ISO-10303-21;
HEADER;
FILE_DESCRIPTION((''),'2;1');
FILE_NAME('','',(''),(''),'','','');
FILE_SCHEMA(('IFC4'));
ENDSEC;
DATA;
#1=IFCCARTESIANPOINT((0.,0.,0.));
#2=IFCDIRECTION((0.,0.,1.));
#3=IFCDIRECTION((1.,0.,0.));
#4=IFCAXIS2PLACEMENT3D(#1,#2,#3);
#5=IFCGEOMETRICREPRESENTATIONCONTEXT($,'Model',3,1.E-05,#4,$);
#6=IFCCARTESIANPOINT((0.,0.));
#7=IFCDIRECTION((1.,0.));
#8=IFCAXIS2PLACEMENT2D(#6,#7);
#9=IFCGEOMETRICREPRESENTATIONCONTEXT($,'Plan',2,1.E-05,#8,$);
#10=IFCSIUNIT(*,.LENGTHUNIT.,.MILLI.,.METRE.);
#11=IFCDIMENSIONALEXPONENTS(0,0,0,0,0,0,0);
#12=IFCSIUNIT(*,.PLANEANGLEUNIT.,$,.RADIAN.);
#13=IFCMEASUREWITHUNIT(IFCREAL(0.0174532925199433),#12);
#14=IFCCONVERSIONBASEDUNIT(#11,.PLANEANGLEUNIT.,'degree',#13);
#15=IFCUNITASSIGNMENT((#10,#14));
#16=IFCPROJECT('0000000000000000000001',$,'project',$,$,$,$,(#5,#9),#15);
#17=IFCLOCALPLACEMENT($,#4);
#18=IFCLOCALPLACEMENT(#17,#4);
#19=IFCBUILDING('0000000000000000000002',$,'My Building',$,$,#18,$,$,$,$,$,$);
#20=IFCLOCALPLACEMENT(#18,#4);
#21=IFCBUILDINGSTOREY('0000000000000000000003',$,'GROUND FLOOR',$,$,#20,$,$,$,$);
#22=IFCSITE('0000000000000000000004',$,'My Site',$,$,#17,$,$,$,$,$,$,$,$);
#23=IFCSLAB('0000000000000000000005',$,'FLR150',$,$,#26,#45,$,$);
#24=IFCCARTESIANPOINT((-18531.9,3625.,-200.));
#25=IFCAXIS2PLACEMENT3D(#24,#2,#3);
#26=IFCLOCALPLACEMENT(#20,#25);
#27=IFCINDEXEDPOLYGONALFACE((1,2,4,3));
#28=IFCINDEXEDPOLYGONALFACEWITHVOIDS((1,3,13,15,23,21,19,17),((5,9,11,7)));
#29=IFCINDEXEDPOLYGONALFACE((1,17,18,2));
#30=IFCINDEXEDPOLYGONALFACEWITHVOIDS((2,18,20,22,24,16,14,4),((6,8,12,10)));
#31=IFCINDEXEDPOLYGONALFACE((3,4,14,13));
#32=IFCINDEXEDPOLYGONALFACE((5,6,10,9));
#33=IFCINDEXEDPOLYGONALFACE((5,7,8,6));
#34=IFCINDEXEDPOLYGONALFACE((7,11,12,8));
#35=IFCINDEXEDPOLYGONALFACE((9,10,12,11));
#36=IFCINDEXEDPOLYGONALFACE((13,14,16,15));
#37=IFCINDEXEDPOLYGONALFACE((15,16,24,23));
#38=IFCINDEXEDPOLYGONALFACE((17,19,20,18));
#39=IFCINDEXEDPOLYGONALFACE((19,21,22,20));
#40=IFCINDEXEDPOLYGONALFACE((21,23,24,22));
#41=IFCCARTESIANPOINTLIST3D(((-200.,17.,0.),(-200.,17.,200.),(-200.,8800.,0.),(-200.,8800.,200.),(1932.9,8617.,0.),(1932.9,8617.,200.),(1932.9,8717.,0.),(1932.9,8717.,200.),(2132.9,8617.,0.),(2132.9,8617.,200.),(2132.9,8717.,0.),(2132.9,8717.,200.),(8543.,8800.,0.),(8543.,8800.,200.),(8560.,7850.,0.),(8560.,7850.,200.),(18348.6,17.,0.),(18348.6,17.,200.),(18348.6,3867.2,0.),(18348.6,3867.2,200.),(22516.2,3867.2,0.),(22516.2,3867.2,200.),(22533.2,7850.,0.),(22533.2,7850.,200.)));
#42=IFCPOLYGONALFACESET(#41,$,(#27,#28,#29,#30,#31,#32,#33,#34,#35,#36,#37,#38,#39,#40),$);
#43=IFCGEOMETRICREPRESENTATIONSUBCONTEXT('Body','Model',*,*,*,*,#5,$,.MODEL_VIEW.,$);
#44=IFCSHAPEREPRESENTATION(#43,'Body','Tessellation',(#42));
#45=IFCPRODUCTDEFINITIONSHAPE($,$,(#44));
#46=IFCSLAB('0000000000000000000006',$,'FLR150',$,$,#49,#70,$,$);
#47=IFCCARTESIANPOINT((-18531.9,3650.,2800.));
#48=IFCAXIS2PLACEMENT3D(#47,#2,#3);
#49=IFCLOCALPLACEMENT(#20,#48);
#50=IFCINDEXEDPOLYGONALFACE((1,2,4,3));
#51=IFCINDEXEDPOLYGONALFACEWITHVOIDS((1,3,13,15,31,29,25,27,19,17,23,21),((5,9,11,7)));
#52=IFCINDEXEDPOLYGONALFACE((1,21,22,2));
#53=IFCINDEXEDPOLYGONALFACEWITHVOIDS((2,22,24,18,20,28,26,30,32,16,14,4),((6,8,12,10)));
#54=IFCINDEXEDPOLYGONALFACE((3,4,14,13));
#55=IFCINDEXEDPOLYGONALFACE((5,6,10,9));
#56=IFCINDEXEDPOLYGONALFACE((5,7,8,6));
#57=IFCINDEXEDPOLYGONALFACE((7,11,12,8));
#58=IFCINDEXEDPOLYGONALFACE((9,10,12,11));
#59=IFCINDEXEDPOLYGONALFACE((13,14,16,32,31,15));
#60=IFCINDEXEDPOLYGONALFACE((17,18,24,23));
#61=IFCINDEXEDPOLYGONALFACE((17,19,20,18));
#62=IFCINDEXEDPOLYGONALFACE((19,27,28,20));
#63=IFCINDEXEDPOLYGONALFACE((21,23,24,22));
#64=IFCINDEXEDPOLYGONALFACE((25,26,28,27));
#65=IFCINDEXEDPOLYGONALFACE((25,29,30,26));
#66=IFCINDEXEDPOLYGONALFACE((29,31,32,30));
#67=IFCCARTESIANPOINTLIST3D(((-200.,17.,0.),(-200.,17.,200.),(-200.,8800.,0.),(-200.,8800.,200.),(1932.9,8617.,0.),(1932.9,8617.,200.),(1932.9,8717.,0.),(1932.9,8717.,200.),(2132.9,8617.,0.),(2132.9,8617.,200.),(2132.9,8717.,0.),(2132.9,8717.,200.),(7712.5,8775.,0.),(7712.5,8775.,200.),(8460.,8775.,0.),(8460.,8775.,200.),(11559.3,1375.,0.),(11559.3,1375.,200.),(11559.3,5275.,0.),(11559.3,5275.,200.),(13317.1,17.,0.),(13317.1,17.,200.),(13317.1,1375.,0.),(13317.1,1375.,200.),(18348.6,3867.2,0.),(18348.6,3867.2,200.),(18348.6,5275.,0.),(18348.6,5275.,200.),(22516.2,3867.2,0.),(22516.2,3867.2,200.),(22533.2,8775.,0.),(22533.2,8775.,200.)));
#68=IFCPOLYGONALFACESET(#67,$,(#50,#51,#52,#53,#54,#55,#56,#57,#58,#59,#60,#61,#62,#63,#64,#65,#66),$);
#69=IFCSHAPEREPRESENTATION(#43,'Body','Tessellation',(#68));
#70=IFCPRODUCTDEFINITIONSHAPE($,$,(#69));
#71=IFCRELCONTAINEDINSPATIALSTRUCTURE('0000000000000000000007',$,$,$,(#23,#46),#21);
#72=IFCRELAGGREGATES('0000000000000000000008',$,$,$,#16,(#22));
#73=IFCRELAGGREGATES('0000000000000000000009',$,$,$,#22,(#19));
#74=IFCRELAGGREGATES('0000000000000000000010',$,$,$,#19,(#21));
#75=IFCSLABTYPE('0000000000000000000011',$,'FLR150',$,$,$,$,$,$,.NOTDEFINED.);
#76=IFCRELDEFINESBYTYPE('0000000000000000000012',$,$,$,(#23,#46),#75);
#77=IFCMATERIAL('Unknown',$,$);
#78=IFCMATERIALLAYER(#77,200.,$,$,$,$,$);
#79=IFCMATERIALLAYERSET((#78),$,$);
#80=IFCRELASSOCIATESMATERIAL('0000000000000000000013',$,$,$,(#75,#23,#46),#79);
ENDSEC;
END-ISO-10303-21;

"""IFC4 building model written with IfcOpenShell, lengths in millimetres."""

from ifc_helpers import new_model, entity, si_unit, converted_unit, frame, origin_with_axes, origin_2d_with_axis, place, context, subcontext, project, spatial, line, indexed_curve, outline, extrude, material, layer, layer_set, layer_usage, type_object, element, save


model = new_model("IFC4")

# Units and contexts
model_context = context("Model", 3, precision=1e-05, world=origin_with_axes())
plan_context = context("Plan", 2, precision=1e-05, world=origin_2d_with_axis())
body_context_1 = subcontext(model_context, "Body", "Model", "MODEL_VIEW")
ifc_project = project(units=[si_unit("LENGTHUNIT", "METRE", prefix="MILLI"), converted_unit("PLANEANGLEUNIT", "degree", entity("IfcReal", 0.0174532925199433), si_unit("PLANEANGLEUNIT", "RADIAN"), dimensions=[0, 0, 0, 0, 0, 0, 0])], contexts=[model_context, plan_context])

# Site, building, storey
site_placement = place(None, origin_with_axes())
site = spatial("IfcSite", under=ifc_project, at=site_placement, Name="My Site")
building_placement = place(site_placement, origin_with_axes())
building = spatial("IfcBuilding", under=site, at=building_placement, Name="My Building")
storey_placement = place(building_placement, origin_with_axes())
storey = spatial("IfcBuildingStorey", under=building, at=storey_placement, Name="GROUND FLOOR")

# Slabs
ifc_material_1 = material(Name="Unknown")
ifc_layer_1 = layer(ifc_material_1, 200.0)
ifc_layer_set_1 = layer_set([ifc_layer_1])
ifc_layer_usage_1 = layer_usage(ifc_layer_set_1, "AXIS3", "POSITIVE", 0.0)
slab_type = type_object("IfcSlabType", Name="FLR150", PredefinedType="NOTDEFINED", material=ifc_layer_set_1)
slab_1_placement = place(storey_placement, frame((-18531.9, 3625.0, -200.0), z_axis=(0.0, 0.0, 1.0), x_axis=(1.0, 0.0, 0.0)))
element("IfcSlab", 1, at=slab_1_placement, inside=storey, type_object=slab_type, material=ifc_layer_usage_1, Name="FLR150", context=body_context_1, shape_type="SweptSolid", body=[
    extrude(outline(indexed_curve([(22533.2, 7850.0), (18348.6, 3867.2), (-200.0, 17.0), (-200.0, 8800.0), (8543.0, 8800.0), (1932.9, 8617.0), (2132.9, 8617.0), (2132.9, 8717.0), (1932.9, 8717.0), (8560.0, 7850.0), (22516.2, 3867.2), (18348.6, 17.0)], segments=[line(5, 10), line(10, 1), line(1, 11), line(11, 2), line(2, 12), line(12, 3), line(3, 4), line(4, 5)], self_intersect=False), holes=[indexed_curve([(22533.2, 7850.0), (18348.6, 3867.2), (-200.0, 17.0), (-200.0, 8800.0), (8543.0, 8800.0), (1932.9, 8617.0), (2132.9, 8617.0), (2132.9, 8717.0), (1932.9, 8717.0), (8560.0, 7850.0), (22516.2, 3867.2), (18348.6, 17.0)], segments=[line(8, 7), line(7, 6), line(6, 9), line(9, 8)], self_intersect=False)]), None, (0.0, 0.0, 1.0), 200.0),
])
ifc_layer_usage_2 = layer_usage(ifc_layer_set_1, "AXIS3", "POSITIVE", 0.0)
slab_2_placement = place(storey_placement, frame((-18531.9, 3650.0, 2800.0), z_axis=(0.0, 0.0, 1.0), x_axis=(1.0, 0.0, 0.0)))
element("IfcSlab", 2, at=slab_2_placement, inside=storey, type_object=slab_type, material=ifc_layer_usage_2, Name="FLR150", context=body_context_1, shape_type="SweptSolid", body=[
    extrude(outline(indexed_curve([(11559.3, 1375.0), (13317.1, 1375.0), (13317.1, 17.0), (-200.0, 17.0), (-200.0, 8800.0), (7712.5, 8775.0), (8460.0, 8775.0), (22533.2, 8775.0), (22516.2, 3867.2), (18348.6, 3867.2), (18348.6, 5275.0), (11559.3, 5275.0), (2132.9, 8617.0), (1932.9, 8617.0), (1932.9, 8717.0), (2132.9, 8717.0)], segments=[line(12, 11), line(11, 10), line(10, 9), line(9, 8), line(8, 7), line(7, 6), line(6, 5), line(5, 4), line(4, 3), line(3, 2), line(2, 1), line(1, 12)], self_intersect=False), holes=[indexed_curve([(11559.3, 1375.0), (13317.1, 1375.0), (13317.1, 17.0), (-200.0, 17.0), (-200.0, 8800.0), (7712.5, 8775.0), (8460.0, 8775.0), (22533.2, 8775.0), (22516.2, 3867.2), (18348.6, 3867.2), (18348.6, 5275.0), (11559.3, 5275.0), (2132.9, 8617.0), (1932.9, 8617.0), (1932.9, 8717.0), (2132.9, 8717.0)], segments=[line(16, 13), line(13, 14), line(14, 15), line(15, 16)], self_intersect=False)]), None, (0.0, 0.0, 1.0), 200.0),
])

save(model, "model.ifc")
